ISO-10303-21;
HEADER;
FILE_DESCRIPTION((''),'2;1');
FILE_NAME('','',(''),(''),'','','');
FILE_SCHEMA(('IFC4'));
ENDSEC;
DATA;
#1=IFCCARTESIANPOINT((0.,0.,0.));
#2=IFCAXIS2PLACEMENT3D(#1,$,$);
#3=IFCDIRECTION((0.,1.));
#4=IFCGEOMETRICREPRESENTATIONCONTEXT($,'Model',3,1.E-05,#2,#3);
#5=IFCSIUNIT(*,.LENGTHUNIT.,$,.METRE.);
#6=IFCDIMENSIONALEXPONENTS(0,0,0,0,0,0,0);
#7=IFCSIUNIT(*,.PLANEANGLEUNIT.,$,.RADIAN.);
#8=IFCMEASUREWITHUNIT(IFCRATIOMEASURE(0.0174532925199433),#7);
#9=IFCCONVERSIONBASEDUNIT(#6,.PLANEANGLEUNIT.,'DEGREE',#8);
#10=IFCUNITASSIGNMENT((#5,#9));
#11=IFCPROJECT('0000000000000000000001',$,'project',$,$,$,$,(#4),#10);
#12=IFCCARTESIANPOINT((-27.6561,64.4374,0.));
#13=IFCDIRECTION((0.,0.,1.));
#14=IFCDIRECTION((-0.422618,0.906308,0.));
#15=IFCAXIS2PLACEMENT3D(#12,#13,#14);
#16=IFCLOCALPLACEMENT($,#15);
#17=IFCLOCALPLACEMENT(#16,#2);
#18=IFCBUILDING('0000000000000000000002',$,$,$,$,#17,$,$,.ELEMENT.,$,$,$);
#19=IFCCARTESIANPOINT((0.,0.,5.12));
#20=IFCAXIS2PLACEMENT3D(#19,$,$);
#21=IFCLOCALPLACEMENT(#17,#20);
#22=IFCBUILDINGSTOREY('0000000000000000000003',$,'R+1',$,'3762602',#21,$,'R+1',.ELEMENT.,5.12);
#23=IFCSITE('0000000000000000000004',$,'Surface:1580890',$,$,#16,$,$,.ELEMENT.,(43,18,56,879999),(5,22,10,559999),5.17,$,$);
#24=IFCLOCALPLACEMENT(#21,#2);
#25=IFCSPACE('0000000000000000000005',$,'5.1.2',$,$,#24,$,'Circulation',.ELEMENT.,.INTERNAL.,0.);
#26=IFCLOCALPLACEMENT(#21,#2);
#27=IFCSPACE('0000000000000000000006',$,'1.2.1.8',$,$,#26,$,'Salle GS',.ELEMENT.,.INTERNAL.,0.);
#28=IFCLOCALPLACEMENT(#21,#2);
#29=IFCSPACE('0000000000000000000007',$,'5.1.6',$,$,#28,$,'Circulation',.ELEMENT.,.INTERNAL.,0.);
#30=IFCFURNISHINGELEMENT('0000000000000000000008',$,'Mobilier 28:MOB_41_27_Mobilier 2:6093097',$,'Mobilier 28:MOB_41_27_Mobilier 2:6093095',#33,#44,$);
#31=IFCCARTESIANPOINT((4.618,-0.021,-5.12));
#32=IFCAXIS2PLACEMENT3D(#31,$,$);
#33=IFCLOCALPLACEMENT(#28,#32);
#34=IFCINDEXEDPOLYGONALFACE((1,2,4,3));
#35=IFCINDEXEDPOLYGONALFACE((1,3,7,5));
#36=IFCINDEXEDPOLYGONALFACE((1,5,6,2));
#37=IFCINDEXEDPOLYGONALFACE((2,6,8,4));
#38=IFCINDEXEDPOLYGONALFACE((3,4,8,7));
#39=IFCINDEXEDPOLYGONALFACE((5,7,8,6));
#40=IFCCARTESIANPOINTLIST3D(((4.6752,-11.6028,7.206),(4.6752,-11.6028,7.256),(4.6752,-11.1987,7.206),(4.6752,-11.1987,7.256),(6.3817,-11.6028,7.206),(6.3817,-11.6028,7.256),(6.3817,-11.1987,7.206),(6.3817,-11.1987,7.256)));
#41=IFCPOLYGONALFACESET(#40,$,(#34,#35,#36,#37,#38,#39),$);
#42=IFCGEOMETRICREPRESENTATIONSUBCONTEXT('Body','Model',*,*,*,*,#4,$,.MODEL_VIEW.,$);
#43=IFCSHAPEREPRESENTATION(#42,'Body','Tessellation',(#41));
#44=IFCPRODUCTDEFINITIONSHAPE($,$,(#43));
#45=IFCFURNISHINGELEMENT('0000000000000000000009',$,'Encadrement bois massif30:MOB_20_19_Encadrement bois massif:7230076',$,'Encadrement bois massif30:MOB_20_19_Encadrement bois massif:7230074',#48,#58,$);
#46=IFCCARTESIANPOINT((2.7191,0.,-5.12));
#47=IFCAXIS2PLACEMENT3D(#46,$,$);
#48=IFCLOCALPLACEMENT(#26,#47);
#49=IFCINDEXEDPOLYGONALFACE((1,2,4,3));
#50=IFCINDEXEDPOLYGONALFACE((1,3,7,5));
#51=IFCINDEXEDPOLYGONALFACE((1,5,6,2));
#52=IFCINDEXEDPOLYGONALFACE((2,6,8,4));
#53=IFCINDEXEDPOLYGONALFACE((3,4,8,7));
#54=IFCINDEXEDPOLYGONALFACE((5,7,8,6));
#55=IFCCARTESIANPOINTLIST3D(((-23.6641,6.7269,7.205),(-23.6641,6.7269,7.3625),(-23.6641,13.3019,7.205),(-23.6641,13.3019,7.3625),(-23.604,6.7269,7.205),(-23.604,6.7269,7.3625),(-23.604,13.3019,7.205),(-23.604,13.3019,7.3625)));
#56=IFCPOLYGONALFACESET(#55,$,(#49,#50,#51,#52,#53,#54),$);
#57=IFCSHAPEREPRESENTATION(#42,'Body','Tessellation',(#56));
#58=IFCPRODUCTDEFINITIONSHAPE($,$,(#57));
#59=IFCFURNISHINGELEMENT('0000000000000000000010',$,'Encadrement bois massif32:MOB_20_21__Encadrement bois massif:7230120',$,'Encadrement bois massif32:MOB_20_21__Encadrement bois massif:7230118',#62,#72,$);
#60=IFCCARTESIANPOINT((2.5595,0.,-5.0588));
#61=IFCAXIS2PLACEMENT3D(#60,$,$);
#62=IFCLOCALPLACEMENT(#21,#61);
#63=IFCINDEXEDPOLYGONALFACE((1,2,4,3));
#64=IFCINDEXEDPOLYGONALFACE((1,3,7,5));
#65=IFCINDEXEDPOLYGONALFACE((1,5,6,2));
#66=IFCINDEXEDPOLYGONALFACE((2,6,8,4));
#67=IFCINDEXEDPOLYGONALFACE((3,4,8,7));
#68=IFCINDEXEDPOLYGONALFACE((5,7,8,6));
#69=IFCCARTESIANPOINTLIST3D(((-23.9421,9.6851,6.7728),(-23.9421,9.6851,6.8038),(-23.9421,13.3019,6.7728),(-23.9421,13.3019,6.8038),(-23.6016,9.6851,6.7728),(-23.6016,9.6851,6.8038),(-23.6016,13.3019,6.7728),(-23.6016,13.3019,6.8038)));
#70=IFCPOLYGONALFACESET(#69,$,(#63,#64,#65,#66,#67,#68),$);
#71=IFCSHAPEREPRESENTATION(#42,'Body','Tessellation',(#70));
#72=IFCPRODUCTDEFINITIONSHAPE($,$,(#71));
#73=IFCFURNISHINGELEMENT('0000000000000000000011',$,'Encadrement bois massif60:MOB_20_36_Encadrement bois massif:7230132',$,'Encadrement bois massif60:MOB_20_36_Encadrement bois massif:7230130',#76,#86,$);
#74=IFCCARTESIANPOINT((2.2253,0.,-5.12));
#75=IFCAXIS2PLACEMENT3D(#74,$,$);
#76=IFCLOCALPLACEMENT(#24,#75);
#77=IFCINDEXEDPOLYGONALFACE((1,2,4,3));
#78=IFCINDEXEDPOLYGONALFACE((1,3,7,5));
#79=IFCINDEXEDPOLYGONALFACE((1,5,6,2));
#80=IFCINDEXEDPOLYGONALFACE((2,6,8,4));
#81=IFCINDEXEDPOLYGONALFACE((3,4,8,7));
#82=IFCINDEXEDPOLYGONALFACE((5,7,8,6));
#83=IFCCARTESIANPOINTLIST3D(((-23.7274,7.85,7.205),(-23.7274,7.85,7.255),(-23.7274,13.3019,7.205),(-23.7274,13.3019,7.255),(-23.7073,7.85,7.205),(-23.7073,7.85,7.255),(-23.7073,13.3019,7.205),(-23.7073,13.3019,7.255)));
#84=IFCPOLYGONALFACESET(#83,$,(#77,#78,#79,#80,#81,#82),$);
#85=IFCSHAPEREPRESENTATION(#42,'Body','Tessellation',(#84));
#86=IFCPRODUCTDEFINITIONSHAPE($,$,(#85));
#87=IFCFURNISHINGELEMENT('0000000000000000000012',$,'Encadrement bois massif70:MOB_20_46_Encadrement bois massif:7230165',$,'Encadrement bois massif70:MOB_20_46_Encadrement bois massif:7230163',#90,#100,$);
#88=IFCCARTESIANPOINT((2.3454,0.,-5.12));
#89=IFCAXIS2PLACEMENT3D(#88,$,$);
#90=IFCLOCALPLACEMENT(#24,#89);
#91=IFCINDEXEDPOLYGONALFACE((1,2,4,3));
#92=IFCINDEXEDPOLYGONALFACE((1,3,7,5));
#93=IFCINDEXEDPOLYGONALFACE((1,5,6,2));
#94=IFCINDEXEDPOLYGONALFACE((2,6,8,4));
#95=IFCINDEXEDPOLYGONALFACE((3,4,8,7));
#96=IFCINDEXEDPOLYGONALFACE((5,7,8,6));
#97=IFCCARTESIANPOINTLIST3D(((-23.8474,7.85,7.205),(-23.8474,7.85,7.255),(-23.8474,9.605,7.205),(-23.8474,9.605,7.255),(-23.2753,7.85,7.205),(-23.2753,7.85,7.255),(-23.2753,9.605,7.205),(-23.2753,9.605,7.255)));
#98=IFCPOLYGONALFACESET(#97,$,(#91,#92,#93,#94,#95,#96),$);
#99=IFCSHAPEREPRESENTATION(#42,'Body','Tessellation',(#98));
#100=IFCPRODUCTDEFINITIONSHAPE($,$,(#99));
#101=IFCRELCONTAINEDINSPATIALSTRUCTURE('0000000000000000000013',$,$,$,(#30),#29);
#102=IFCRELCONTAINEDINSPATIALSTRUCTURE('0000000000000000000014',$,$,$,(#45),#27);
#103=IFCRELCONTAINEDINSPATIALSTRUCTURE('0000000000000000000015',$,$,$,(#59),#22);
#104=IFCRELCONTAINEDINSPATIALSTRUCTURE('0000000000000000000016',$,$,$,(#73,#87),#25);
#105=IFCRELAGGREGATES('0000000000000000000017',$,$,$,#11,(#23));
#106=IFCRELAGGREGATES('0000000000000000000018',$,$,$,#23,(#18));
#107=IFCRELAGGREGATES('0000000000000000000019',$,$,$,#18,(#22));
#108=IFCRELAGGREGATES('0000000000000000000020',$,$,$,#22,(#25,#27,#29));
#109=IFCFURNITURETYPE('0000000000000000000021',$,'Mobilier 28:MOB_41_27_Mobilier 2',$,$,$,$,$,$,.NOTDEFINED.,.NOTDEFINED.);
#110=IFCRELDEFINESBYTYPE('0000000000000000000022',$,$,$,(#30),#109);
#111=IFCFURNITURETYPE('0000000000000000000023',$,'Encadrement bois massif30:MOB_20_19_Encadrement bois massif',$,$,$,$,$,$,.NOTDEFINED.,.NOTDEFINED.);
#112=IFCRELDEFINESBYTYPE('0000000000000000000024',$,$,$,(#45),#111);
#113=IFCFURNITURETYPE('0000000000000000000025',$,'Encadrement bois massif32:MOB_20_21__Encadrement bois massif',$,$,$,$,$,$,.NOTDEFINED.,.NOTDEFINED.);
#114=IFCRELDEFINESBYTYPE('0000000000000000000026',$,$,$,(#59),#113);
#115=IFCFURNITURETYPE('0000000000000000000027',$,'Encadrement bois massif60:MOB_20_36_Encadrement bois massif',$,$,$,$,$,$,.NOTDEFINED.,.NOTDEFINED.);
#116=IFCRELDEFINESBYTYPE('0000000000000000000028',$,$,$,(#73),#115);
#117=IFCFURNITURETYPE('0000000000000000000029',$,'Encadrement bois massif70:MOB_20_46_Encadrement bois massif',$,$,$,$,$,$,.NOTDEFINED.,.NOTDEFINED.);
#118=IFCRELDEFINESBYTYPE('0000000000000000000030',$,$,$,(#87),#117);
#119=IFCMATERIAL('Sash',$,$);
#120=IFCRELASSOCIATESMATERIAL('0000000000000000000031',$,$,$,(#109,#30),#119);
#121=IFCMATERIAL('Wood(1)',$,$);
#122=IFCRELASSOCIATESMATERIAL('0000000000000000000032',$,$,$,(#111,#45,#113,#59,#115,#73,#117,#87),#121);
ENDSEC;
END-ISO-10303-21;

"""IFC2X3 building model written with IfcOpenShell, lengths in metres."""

from ifc_helpers import new_model, entity, si_unit, converted_unit, direction, frame, frame_2d, origin, place, context, subcontext, project, spatial, rectangle, extrude, source, transform, mapped, material, type_object, type_shapes, element, save


model = new_model("IFC2X3")

# Units and contexts
model_context = context("Model", 3, precision=1e-05, world=origin(), true_north=direction((0.0, 1.0)))
body_context = subcontext(model_context, "Body", "Model", "MODEL_VIEW")
ifc_project = project(units=[si_unit("LENGTHUNIT", "METRE"), converted_unit("PLANEANGLEUNIT", "DEGREE", entity("IfcRatioMeasure", 0.0174532925199433), si_unit("PLANEANGLEUNIT", "RADIAN"), dimensions=[0, 0, 0, 0, 0, 0, 0])], contexts=[model_context])

# Site, building, storey
site_placement = place(None, frame((-27.6561, 64.4374, 0.0), z_axis=(0.0, 0.0, 1.0), x_axis=(-0.422618, 0.906308, 0.0)))
site = spatial("IfcSite", under=ifc_project, at=site_placement, Name="Surface:1580890", CompositionType="ELEMENT", RefLatitude=(43, 18, 56, 879999), RefLongitude=(5, 22, 10, 559999), RefElevation=5.17)
building_placement = place(site_placement, origin())
building = spatial("IfcBuilding", under=site, at=building_placement, CompositionType="ELEMENT")
storey_placement = place(building_placement, frame((0.0, 0.0, 5.12)))
storey = spatial("IfcBuildingStorey", under=building, at=storey_placement, Name="R+1", ObjectType="3762602", LongName="R+1", CompositionType="ELEMENT", Elevation=5.12)

# Shared definitions
ifc_material_1 = material(Name="Wood(1)")

# Shared definitions
space_1_placement = place(storey_placement, origin())
space_1 = spatial("IfcSpace", under=storey, at=space_1_placement, Name="5.1.2", LongName="Circulation", CompositionType="ELEMENT", InteriorOrExteriorSpace="INTERNAL", ElevationWithFlooring=0.0)

# Shared definitions
space_2_placement = place(storey_placement, origin())
space_2 = spatial("IfcSpace", under=storey, at=space_2_placement, Name="1.2.1.8", LongName="Salle GS", CompositionType="ELEMENT", InteriorOrExteriorSpace="INTERNAL", ElevationWithFlooring=0.0)

# Shared definitions
ifc_material_2 = material(Name="Sash")

# Shared definitions
space_3_placement = place(storey_placement, origin())
space_3 = spatial("IfcSpace", under=storey, at=space_3_placement, Name="5.1.6", LongName="Circulation", CompositionType="ELEMENT", InteriorOrExteriorSpace="INTERNAL", ElevationWithFlooring=0.0)

# Furnishing elements
furniture_type_1 = type_object("IfcFurnitureType", Name="Mobilier 28:MOB_41_27_Mobilier 2", material=ifc_material_2)
shared_shape_1 = source(origin(), body_context, "Body", "SweptSolid", [
    extrude(rectangle(XDim=0.4041, YDim=1.7065, at=frame_2d((0.0, 0.0), x_axis=(1.0, 0.0))), frame((5.5284, -11.4007, 7.206), z_axis=(0.0, 0.0, 1.0), x_axis=(0.0, -1.0, 0.0)), (0.0, 0.0, 1.0), 0.05),
])
type_shapes(furniture_type_1, [shared_shape_1])
furnishing_1_placement = place(space_3_placement, frame((4.618, -0.021, -5.12)))
element("IfcFurnishingElement", 1, at=furnishing_1_placement, inside=space_3, type_object=furniture_type_1, material=ifc_material_2, Name="Mobilier 28:MOB_41_27_Mobilier 2:6093097", ObjectType="Mobilier 28:MOB_41_27_Mobilier 2:6093095", context=body_context, shape_type="MappedRepresentation", body=[
    mapped(shared_shape_1, transform((0.0, 0.0, 0.0), scale=1.0)),
])
furniture_type_2 = type_object("IfcFurnitureType", Name="Encadrement bois massif30:MOB_20_19_Encadrement bois massif", material=ifc_material_1)
shared_shape_2 = source(origin(), body_context, "Body", "SweptSolid", [
    extrude(rectangle(XDim=6.575, YDim=0.0601, at=frame_2d((0.0, 0.0), x_axis=(1.0, 0.0))), frame((-23.6341, 10.0144, 7.205), z_axis=(0.0, 0.0, 1.0), x_axis=(0.0, -1.0, 0.0)), (0.0, 0.0, 1.0), 0.1575),
])
type_shapes(furniture_type_2, [shared_shape_2])
furnishing_2_placement = place(space_2_placement, frame((2.7191, 0.0, -5.12)))
element("IfcFurnishingElement", 2, at=furnishing_2_placement, inside=space_2, type_object=furniture_type_2, material=ifc_material_1, Name="Encadrement bois massif30:MOB_20_19_Encadrement bois massif:7230076", ObjectType="Encadrement bois massif30:MOB_20_19_Encadrement bois massif:7230074", context=body_context, shape_type="MappedRepresentation", body=[
    mapped(shared_shape_2, transform((0.0, 0.0, 0.0), scale=1.0)),
])
furniture_type_3 = type_object("IfcFurnitureType", Name="Encadrement bois massif32:MOB_20_21__Encadrement bois massif", material=ifc_material_1)
shared_shape_3 = source(origin(), body_context, "Body", "SweptSolid", [
    extrude(rectangle(XDim=3.6168, YDim=0.3405, at=frame_2d((0.0, 0.0), x_axis=(1.0, 0.0))), frame((-23.7718, 11.4935, 6.7728), z_axis=(0.0, 0.0, 1.0), x_axis=(0.0, -1.0, 0.0)), (0.0, 0.0, 1.0), 0.031),
])
type_shapes(furniture_type_3, [shared_shape_3])
furnishing_3_placement = place(storey_placement, frame((2.5595, 0.0, -5.0588)))
element("IfcFurnishingElement", 3, at=furnishing_3_placement, inside=storey, type_object=furniture_type_3, material=ifc_material_1, Name="Encadrement bois massif32:MOB_20_21__Encadrement bois massif:7230120", ObjectType="Encadrement bois massif32:MOB_20_21__Encadrement bois massif:7230118", context=body_context, shape_type="MappedRepresentation", body=[
    mapped(shared_shape_3, transform((0.0, 0.0, 0.0), scale=1.0)),
])
furniture_type_4 = type_object("IfcFurnitureType", Name="Encadrement bois massif60:MOB_20_36_Encadrement bois massif", material=ifc_material_1)
shared_shape_4 = source(origin(), body_context, "Body", "SweptSolid", [
    extrude(rectangle(XDim=5.4519, YDim=0.0201, at=frame_2d((0.0, 0.0), x_axis=(1.0, 0.0))), frame((-23.7173, 10.5759, 7.205), z_axis=(0.0, 0.0, 1.0), x_axis=(0.0, -1.0, 0.0)), (0.0, 0.0, 1.0), 0.05),
])
type_shapes(furniture_type_4, [shared_shape_4])
furnishing_4_placement = place(space_1_placement, frame((2.2253, 0.0, -5.12)))
element("IfcFurnishingElement", 4, at=furnishing_4_placement, inside=space_1, type_object=furniture_type_4, material=ifc_material_1, Name="Encadrement bois massif60:MOB_20_36_Encadrement bois massif:7230132", ObjectType="Encadrement bois massif60:MOB_20_36_Encadrement bois massif:7230130", context=body_context, shape_type="MappedRepresentation", body=[
    mapped(shared_shape_4, transform((0.0, 0.0, 0.0), scale=1.0)),
])
furniture_type_5 = type_object("IfcFurnitureType", Name="Encadrement bois massif70:MOB_20_46_Encadrement bois massif", material=ifc_material_1)
shared_shape_5 = source(origin(), body_context, "Body", "SweptSolid", [
    extrude(rectangle(XDim=1.755, YDim=0.5721, at=frame_2d((0.0, 0.0), x_axis=(1.0, 0.0))), frame((-23.5613, 8.7275, 7.205), z_axis=(0.0, 0.0, 1.0), x_axis=(0.0, -1.0, 0.0)), (0.0, 0.0, 1.0), 0.05),
])
type_shapes(furniture_type_5, [shared_shape_5])
furnishing_5_placement = place(space_1_placement, frame((2.3454, 0.0, -5.12)))
element("IfcFurnishingElement", 5, at=furnishing_5_placement, inside=space_1, type_object=furniture_type_5, material=ifc_material_1, Name="Encadrement bois massif70:MOB_20_46_Encadrement bois massif:7230165", ObjectType="Encadrement bois massif70:MOB_20_46_Encadrement bois massif:7230163", context=body_context, shape_type="MappedRepresentation", body=[
    mapped(shared_shape_5, transform((0.0, 0.0, 0.0), scale=1.0)),
])

save(model, "model.ifc")
